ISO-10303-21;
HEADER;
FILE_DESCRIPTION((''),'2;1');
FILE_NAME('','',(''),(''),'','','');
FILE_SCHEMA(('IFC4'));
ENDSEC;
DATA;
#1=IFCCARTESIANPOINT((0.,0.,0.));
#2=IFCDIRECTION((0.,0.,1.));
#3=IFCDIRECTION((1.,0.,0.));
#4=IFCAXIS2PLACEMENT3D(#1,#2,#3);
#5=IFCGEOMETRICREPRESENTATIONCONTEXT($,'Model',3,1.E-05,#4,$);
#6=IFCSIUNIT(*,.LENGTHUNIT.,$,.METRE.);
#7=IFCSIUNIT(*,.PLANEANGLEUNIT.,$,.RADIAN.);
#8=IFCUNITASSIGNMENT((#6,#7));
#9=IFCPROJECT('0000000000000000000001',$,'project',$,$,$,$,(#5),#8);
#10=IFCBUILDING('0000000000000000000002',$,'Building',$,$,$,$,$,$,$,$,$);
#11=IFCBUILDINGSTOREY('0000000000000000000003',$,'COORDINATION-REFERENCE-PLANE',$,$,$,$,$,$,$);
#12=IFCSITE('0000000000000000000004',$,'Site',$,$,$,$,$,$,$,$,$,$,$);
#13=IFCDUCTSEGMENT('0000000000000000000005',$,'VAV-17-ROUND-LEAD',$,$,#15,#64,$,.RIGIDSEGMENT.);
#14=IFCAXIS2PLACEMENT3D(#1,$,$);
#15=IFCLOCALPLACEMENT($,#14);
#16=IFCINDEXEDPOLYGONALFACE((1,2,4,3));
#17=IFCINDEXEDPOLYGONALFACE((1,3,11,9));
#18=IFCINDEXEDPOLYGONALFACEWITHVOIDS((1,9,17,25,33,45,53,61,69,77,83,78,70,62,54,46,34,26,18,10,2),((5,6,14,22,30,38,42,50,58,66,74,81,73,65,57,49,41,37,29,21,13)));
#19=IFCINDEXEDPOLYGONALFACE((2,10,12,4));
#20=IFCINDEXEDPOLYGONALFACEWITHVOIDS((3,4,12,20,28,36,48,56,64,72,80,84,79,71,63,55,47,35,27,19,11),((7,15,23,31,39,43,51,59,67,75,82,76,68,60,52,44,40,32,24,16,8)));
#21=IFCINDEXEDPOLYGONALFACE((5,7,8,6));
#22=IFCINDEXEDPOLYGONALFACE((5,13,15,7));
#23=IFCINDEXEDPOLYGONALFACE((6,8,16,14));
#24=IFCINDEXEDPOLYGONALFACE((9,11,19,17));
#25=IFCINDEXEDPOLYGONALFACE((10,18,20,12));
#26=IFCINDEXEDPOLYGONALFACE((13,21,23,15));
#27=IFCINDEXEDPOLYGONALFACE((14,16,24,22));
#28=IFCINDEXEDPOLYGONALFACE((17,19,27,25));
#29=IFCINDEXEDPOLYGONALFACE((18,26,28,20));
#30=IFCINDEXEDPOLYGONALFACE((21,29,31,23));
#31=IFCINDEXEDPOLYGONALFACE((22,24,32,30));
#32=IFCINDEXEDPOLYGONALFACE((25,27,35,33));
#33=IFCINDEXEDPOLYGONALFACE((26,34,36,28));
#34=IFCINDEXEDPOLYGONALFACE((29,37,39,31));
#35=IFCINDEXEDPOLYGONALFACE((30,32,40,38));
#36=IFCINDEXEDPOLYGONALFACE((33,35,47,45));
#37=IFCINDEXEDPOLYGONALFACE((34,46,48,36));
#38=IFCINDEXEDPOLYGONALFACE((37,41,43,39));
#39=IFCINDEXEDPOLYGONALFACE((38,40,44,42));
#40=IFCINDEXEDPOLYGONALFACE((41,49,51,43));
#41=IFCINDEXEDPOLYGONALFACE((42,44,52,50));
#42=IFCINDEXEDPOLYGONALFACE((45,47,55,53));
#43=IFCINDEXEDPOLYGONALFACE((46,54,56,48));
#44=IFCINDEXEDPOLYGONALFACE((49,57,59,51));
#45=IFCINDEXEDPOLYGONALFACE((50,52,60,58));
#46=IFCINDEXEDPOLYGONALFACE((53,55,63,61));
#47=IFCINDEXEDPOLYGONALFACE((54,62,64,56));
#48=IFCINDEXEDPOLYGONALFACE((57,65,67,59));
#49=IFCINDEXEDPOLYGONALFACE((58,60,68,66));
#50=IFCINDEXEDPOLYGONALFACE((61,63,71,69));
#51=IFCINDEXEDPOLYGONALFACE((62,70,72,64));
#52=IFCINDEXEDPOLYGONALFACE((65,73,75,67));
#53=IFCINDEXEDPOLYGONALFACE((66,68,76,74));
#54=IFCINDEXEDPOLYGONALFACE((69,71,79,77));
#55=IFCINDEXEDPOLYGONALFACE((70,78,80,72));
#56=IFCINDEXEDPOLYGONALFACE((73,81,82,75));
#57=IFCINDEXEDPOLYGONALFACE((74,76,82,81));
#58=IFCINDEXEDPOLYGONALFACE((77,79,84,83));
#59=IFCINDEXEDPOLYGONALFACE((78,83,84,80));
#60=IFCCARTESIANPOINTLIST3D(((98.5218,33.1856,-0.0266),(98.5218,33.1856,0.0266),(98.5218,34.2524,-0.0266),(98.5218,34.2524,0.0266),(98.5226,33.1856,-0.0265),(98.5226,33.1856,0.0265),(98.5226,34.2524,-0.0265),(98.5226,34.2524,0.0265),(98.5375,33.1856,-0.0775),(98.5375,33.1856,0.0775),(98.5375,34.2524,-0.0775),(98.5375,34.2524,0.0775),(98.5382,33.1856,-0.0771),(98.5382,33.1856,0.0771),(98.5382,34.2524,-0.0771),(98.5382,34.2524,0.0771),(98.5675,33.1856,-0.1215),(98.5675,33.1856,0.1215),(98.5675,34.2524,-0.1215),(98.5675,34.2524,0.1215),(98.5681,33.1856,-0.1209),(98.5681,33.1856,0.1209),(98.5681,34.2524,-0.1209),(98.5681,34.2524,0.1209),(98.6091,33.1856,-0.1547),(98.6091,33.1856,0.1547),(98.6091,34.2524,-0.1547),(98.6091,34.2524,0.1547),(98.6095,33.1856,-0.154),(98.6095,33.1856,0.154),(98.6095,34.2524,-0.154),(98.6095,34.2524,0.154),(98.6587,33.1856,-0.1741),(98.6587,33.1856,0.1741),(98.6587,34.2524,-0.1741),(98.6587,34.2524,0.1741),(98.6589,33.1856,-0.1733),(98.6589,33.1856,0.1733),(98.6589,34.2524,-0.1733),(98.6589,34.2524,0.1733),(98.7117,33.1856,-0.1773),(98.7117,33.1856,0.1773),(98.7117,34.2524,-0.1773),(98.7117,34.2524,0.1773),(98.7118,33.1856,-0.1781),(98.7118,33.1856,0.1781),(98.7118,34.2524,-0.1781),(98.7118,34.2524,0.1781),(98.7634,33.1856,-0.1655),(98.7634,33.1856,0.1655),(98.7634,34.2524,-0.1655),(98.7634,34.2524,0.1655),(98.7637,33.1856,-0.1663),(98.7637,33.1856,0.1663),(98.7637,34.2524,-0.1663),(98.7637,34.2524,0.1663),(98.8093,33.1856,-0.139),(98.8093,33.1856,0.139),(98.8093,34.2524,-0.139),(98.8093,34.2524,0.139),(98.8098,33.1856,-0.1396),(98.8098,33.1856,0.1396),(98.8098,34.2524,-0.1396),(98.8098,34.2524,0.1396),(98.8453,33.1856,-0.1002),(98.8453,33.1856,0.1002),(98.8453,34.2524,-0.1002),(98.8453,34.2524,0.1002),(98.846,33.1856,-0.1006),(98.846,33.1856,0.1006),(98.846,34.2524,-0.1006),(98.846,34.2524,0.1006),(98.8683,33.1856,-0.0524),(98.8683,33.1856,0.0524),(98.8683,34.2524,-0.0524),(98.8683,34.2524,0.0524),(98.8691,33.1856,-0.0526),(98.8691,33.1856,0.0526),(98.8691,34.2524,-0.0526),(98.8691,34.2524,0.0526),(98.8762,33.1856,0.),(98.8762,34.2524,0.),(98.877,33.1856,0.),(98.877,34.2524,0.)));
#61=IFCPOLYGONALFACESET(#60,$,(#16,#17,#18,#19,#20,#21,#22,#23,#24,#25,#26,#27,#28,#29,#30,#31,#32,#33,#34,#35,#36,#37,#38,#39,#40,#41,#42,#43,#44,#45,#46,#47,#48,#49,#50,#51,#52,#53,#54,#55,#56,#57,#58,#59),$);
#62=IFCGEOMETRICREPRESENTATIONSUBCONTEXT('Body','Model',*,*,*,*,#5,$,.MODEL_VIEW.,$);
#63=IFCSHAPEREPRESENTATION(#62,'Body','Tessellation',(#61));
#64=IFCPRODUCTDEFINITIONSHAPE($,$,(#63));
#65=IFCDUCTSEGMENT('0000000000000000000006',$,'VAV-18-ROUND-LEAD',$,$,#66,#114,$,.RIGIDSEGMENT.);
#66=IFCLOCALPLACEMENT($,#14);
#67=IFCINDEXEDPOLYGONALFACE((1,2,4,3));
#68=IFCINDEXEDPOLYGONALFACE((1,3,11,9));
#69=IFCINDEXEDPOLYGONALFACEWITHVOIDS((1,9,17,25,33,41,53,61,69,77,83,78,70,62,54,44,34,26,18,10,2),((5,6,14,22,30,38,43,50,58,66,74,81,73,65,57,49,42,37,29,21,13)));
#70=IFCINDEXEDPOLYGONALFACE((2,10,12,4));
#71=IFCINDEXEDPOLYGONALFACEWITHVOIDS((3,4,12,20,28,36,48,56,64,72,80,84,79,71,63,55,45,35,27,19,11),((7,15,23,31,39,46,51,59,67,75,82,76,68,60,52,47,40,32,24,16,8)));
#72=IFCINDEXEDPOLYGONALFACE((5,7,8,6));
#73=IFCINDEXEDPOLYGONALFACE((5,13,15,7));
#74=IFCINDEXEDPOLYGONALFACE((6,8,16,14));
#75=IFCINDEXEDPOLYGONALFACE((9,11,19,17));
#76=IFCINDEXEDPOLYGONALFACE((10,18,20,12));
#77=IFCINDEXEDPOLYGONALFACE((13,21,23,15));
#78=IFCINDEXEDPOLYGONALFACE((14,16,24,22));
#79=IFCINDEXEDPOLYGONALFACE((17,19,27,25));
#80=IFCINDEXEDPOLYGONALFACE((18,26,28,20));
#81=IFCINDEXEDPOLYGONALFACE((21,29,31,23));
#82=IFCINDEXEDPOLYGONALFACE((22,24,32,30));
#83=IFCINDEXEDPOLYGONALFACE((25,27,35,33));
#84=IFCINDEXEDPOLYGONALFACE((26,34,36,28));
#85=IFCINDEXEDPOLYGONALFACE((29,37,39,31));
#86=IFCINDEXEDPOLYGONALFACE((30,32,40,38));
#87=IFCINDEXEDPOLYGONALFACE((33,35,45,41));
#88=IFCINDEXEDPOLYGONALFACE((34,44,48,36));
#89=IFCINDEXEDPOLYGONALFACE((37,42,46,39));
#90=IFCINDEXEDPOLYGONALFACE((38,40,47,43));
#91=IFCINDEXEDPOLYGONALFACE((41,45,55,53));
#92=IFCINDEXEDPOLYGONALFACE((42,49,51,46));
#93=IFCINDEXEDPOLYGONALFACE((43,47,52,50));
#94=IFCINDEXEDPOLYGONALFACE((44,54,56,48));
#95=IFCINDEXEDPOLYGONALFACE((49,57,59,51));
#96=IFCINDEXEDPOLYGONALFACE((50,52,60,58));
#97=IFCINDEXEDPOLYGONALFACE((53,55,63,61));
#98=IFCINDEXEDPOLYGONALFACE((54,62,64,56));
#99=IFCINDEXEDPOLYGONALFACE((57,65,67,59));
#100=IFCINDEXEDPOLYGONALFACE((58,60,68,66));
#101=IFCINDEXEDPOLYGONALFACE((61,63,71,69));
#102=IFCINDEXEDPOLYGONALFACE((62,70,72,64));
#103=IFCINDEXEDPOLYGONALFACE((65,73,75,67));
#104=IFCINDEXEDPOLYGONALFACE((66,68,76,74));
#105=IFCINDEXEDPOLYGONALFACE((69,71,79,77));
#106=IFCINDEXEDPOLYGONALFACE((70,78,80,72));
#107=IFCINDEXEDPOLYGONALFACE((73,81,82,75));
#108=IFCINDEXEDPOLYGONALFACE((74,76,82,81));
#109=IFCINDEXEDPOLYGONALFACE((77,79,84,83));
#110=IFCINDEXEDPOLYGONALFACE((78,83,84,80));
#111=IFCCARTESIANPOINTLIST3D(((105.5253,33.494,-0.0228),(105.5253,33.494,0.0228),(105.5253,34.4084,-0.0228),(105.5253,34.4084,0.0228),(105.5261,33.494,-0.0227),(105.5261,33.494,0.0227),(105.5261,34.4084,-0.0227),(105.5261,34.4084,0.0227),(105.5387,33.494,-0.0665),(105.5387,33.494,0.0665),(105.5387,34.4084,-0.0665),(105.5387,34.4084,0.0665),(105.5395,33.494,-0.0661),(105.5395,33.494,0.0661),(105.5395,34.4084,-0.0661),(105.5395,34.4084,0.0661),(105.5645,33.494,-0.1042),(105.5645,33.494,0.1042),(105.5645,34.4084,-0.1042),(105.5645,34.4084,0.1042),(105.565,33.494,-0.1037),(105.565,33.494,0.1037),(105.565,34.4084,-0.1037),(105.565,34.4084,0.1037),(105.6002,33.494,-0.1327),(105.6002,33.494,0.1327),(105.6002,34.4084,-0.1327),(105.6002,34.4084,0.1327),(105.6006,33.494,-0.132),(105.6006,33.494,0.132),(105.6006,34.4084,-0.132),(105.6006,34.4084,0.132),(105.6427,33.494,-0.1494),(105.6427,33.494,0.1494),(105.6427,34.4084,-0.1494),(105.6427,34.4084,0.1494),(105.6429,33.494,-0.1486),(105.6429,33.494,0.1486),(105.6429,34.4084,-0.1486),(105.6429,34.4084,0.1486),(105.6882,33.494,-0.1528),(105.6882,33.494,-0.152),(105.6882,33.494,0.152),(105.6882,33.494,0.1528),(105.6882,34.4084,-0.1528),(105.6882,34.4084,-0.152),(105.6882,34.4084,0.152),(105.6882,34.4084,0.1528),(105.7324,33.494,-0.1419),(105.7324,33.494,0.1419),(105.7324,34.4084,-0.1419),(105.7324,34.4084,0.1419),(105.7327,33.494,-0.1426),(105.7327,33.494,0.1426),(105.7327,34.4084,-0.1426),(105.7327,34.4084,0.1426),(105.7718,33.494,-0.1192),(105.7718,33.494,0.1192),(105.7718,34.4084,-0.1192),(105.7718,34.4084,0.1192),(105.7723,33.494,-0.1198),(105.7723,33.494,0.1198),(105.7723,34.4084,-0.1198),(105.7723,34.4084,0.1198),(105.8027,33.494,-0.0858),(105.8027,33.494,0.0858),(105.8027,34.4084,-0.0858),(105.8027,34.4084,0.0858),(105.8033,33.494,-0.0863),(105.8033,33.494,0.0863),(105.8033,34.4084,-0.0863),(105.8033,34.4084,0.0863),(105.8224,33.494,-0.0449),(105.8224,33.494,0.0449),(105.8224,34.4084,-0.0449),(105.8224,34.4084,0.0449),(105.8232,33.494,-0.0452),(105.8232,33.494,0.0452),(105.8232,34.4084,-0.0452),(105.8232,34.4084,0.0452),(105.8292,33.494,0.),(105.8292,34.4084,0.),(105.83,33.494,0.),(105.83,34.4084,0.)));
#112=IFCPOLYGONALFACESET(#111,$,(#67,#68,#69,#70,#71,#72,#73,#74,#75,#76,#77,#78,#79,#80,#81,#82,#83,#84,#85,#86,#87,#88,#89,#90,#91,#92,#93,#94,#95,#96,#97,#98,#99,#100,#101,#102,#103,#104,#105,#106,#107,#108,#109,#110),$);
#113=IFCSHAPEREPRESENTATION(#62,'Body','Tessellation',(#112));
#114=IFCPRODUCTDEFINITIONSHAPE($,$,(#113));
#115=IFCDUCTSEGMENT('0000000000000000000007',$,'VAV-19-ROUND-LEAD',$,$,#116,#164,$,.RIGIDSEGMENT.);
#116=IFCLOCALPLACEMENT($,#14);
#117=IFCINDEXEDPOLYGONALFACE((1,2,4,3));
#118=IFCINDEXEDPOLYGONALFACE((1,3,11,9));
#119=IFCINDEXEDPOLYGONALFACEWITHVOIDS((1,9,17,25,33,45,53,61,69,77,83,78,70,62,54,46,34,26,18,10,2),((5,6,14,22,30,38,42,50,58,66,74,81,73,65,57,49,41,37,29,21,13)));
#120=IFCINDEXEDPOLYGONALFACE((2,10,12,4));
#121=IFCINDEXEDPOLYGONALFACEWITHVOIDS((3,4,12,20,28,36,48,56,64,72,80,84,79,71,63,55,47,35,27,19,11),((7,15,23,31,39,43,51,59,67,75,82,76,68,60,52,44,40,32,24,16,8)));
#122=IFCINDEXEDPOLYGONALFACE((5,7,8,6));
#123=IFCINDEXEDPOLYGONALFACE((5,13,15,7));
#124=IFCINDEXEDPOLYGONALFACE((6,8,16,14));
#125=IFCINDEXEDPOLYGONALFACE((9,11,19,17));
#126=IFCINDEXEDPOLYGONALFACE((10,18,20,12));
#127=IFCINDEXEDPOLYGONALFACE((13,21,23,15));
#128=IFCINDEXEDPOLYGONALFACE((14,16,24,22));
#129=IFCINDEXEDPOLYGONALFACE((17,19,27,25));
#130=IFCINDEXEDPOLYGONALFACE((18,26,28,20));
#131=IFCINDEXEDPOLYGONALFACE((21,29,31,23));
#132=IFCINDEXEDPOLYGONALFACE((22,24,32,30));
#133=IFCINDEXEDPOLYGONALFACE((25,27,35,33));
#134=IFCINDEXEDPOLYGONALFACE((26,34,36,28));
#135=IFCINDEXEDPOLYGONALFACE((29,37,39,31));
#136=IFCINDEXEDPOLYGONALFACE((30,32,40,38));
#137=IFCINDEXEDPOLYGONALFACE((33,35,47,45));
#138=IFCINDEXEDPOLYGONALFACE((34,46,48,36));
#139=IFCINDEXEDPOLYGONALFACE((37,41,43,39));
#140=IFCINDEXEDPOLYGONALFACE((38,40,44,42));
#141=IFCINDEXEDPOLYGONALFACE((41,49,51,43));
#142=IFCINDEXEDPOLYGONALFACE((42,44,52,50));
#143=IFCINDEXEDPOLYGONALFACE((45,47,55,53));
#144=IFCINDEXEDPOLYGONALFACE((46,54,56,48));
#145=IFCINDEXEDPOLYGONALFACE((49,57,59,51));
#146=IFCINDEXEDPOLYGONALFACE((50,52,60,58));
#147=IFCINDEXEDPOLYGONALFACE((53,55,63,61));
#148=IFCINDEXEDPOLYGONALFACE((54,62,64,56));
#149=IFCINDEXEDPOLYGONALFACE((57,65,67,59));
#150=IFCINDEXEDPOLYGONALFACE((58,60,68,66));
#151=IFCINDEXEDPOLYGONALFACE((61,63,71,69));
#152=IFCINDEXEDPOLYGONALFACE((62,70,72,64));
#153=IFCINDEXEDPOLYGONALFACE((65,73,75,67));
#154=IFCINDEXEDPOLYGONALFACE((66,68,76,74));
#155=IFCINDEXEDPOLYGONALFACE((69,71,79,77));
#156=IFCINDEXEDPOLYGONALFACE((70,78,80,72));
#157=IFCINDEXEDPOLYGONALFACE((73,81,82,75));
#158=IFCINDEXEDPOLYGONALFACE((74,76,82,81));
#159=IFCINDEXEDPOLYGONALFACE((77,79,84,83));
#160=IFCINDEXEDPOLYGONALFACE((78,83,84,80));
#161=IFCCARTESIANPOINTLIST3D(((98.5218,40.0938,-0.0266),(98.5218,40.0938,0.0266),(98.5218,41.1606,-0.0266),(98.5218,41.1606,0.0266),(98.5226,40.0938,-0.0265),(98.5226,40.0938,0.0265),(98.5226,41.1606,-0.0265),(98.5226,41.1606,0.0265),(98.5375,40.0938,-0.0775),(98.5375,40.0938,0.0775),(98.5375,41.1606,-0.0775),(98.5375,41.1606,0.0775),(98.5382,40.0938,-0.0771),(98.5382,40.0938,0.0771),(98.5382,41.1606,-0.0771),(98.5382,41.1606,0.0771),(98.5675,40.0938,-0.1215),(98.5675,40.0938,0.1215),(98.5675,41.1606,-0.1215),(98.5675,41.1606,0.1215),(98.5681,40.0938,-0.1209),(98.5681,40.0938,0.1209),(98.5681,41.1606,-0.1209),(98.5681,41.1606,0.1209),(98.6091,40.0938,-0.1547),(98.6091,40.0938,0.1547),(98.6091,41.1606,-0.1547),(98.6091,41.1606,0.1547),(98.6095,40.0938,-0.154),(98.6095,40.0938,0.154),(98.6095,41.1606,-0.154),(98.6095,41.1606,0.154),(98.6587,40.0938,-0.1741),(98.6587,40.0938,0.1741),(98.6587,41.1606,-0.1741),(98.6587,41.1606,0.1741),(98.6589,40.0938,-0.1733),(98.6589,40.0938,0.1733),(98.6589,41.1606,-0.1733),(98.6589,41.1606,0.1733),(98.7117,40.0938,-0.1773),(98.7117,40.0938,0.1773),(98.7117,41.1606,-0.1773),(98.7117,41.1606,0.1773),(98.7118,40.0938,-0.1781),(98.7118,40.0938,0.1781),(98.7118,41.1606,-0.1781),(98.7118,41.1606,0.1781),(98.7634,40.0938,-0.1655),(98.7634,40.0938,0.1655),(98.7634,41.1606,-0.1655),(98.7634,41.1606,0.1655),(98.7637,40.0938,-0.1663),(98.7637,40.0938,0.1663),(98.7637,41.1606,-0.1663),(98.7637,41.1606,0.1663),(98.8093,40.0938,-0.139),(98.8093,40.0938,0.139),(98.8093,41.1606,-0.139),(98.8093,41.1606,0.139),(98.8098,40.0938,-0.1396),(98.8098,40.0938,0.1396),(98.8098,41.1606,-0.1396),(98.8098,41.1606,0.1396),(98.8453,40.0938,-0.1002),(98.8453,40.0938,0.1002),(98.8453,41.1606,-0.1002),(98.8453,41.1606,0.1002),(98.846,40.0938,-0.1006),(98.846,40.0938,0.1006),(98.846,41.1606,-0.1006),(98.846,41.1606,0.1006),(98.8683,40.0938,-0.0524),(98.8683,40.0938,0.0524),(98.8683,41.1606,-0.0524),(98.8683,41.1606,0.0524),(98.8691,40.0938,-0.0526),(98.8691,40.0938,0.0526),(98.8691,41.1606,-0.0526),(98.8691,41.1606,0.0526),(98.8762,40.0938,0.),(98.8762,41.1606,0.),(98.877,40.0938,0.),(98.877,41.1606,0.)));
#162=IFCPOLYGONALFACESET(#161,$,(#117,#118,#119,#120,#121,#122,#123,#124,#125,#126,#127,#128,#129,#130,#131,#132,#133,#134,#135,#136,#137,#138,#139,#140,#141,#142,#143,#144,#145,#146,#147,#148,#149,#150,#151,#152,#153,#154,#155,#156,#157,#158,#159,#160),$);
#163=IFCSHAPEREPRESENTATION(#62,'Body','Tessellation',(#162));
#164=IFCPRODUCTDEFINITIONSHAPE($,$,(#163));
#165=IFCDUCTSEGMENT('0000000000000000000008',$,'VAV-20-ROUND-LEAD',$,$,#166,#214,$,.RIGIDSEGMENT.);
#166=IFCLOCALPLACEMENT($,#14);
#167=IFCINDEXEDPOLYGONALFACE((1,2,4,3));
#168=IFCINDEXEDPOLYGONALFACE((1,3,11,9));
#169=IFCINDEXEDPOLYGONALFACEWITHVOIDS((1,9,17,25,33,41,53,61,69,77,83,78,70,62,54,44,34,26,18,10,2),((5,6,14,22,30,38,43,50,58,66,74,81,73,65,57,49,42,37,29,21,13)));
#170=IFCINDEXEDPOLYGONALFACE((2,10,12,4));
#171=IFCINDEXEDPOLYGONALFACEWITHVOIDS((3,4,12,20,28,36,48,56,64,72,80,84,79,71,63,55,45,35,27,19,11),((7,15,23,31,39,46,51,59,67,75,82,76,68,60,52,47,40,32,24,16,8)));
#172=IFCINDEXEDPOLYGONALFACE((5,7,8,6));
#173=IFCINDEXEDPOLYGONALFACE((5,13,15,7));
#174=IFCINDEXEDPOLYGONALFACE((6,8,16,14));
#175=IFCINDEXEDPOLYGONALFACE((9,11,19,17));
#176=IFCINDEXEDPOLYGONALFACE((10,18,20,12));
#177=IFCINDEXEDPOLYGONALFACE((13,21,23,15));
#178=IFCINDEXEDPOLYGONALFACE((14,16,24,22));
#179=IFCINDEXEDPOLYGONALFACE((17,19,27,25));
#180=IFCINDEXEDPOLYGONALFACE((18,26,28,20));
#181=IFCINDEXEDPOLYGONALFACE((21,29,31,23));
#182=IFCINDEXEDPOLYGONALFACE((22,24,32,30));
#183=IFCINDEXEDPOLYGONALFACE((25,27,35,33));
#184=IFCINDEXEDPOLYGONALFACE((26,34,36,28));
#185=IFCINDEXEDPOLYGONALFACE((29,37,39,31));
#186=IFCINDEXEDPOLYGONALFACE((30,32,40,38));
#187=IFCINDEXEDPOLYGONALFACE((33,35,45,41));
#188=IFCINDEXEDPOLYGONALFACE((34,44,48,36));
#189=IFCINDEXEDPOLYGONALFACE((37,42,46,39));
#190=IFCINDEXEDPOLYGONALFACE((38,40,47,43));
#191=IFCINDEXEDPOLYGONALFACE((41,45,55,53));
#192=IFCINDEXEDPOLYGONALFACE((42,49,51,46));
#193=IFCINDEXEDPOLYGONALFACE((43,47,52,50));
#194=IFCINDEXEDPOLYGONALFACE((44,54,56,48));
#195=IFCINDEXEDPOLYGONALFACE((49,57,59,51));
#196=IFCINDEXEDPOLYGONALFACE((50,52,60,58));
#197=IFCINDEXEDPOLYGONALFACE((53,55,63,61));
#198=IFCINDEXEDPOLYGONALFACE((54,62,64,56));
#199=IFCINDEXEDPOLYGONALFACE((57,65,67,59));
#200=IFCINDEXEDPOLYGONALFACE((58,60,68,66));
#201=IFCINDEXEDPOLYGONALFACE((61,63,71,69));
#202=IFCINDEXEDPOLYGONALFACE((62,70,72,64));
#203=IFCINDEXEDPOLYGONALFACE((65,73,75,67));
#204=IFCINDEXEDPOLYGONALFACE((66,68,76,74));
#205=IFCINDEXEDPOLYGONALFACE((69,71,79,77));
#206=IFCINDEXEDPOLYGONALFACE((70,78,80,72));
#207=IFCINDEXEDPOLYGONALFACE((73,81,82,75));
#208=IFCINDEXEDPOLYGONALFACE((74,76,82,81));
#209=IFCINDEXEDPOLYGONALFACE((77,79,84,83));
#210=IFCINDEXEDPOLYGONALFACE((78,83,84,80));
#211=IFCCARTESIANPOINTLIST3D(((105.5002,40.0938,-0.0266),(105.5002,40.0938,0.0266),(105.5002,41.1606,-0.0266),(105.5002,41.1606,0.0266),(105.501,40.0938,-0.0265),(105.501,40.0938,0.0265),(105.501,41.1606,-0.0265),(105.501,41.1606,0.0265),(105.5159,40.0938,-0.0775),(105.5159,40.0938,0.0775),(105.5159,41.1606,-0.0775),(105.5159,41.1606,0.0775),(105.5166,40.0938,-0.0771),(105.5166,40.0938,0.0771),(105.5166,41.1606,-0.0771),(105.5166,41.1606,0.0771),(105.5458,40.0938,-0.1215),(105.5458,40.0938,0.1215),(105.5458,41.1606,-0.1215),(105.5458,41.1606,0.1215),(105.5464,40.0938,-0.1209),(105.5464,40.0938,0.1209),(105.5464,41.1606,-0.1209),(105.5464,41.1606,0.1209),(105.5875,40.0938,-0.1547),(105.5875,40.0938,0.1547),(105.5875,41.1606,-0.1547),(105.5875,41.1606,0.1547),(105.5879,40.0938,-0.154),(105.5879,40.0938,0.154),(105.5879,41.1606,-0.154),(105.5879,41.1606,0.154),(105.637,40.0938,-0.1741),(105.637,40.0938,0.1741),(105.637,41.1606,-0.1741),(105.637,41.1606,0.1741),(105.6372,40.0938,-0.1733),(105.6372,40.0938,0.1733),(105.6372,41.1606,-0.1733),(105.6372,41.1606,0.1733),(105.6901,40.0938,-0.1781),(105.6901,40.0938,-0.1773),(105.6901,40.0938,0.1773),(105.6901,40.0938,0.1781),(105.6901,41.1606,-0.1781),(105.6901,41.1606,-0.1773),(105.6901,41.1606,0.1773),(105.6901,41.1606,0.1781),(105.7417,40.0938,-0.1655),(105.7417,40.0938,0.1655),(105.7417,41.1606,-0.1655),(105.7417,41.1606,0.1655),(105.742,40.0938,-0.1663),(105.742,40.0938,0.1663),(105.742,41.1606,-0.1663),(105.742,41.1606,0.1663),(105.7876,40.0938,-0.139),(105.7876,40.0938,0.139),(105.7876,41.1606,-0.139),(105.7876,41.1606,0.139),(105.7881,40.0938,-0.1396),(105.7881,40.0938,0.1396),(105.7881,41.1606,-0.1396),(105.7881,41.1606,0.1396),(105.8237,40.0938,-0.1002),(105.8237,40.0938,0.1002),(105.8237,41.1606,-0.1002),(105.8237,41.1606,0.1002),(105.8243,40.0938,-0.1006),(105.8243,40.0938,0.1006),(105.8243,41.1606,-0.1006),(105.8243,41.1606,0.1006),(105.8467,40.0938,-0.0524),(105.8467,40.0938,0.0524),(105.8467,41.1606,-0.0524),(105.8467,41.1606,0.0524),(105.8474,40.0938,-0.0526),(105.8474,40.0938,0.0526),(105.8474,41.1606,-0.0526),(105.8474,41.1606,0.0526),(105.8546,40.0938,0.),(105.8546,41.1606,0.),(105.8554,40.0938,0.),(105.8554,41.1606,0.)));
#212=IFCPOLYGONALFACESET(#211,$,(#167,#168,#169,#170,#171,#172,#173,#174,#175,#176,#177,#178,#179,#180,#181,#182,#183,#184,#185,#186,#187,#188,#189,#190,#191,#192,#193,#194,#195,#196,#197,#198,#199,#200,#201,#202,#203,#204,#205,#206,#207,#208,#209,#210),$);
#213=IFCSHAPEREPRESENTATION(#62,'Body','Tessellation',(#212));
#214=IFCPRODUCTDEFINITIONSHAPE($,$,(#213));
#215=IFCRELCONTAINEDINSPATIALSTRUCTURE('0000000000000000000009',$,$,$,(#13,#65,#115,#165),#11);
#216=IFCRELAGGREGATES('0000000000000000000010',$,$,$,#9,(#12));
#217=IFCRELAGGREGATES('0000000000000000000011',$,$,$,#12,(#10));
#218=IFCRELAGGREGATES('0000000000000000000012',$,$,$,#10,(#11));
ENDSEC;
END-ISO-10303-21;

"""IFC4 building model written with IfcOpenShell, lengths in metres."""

from ifc_helpers import new_model, si_unit, frame, origin, origin_with_axes, place, context, subcontext, project, spatial, hollow_circle, extrude, element, save


model = new_model("IFC4")

# Units and contexts
model_context = context("Model", 3, precision=1e-05, world=origin_with_axes())
body_context_1 = subcontext(model_context, "Body", "Model", "MODEL_VIEW")
ifc_project = project(units=[si_unit("LENGTHUNIT", "METRE"), si_unit("PLANEANGLEUNIT", "RADIAN")], contexts=[model_context])

# Site, building, storey
site = spatial("IfcSite", under=ifc_project, Name="Site")
building = spatial("IfcBuilding", under=site, Name="Building")
storey = spatial("IfcBuildingStorey", under=building, Name="COORDINATION-REFERENCE-PLANE")

# Duct segments
for number, where, z_axis, x_axis, name in (
    (1, (98.6984, 34.2524, 0.0), (0.0, -1.0, 0.0), (1.0, 0.0, 0.0), "VAV-17-ROUND-LEAD"),
):
    element("IfcDuctSegment", number, at=place(None, frame(where, z_axis=z_axis, x_axis=x_axis)), inside=storey, Name=name, PredefinedType="RIGIDSEGMENT", context=body_context_1, shape_type="SweptSolid", body=[
        extrude(hollow_circle(Radius=0.1786, WallThickness=0.0008), origin(), (0.0, 0.0, 1.0), 1.0668),
    ])
duct_segment_1_placement = place(None, frame((105.6768, 34.4084, 0.0), z_axis=(0.0, -1.0, 0.0), x_axis=(1.0, 0.0, 0.0)))
element("IfcDuctSegment", 2, at=duct_segment_1_placement, inside=storey, Name="VAV-18-ROUND-LEAD", PredefinedType="RIGIDSEGMENT", context=body_context_1, shape_type="SweptSolid", body=[
    extrude(hollow_circle(Radius=0.1532, WallThickness=0.0008), origin(), (0.0, 0.0, 1.0), 0.9144),
])
for number, where, z_axis, x_axis, name in (
    (3, (98.6984, 40.0938, 0.0), (0.0, 1.0, 0.0), (1.0, 0.0, 0.0), "VAV-19-ROUND-LEAD"),
    (4, (105.6768, 40.0938, 0.0), (0.0, 1.0, 0.0), (1.0, 0.0, 0.0), "VAV-20-ROUND-LEAD"),
):
    element("IfcDuctSegment", number, at=place(None, frame(where, z_axis=z_axis, x_axis=x_axis)), inside=storey, Name=name, PredefinedType="RIGIDSEGMENT", context=body_context_1, shape_type="SweptSolid", body=[
        extrude(hollow_circle(Radius=0.1786, WallThickness=0.0008), origin(), (0.0, 0.0, 1.0), 1.0668),
    ])

save(model, "model.ifc")
